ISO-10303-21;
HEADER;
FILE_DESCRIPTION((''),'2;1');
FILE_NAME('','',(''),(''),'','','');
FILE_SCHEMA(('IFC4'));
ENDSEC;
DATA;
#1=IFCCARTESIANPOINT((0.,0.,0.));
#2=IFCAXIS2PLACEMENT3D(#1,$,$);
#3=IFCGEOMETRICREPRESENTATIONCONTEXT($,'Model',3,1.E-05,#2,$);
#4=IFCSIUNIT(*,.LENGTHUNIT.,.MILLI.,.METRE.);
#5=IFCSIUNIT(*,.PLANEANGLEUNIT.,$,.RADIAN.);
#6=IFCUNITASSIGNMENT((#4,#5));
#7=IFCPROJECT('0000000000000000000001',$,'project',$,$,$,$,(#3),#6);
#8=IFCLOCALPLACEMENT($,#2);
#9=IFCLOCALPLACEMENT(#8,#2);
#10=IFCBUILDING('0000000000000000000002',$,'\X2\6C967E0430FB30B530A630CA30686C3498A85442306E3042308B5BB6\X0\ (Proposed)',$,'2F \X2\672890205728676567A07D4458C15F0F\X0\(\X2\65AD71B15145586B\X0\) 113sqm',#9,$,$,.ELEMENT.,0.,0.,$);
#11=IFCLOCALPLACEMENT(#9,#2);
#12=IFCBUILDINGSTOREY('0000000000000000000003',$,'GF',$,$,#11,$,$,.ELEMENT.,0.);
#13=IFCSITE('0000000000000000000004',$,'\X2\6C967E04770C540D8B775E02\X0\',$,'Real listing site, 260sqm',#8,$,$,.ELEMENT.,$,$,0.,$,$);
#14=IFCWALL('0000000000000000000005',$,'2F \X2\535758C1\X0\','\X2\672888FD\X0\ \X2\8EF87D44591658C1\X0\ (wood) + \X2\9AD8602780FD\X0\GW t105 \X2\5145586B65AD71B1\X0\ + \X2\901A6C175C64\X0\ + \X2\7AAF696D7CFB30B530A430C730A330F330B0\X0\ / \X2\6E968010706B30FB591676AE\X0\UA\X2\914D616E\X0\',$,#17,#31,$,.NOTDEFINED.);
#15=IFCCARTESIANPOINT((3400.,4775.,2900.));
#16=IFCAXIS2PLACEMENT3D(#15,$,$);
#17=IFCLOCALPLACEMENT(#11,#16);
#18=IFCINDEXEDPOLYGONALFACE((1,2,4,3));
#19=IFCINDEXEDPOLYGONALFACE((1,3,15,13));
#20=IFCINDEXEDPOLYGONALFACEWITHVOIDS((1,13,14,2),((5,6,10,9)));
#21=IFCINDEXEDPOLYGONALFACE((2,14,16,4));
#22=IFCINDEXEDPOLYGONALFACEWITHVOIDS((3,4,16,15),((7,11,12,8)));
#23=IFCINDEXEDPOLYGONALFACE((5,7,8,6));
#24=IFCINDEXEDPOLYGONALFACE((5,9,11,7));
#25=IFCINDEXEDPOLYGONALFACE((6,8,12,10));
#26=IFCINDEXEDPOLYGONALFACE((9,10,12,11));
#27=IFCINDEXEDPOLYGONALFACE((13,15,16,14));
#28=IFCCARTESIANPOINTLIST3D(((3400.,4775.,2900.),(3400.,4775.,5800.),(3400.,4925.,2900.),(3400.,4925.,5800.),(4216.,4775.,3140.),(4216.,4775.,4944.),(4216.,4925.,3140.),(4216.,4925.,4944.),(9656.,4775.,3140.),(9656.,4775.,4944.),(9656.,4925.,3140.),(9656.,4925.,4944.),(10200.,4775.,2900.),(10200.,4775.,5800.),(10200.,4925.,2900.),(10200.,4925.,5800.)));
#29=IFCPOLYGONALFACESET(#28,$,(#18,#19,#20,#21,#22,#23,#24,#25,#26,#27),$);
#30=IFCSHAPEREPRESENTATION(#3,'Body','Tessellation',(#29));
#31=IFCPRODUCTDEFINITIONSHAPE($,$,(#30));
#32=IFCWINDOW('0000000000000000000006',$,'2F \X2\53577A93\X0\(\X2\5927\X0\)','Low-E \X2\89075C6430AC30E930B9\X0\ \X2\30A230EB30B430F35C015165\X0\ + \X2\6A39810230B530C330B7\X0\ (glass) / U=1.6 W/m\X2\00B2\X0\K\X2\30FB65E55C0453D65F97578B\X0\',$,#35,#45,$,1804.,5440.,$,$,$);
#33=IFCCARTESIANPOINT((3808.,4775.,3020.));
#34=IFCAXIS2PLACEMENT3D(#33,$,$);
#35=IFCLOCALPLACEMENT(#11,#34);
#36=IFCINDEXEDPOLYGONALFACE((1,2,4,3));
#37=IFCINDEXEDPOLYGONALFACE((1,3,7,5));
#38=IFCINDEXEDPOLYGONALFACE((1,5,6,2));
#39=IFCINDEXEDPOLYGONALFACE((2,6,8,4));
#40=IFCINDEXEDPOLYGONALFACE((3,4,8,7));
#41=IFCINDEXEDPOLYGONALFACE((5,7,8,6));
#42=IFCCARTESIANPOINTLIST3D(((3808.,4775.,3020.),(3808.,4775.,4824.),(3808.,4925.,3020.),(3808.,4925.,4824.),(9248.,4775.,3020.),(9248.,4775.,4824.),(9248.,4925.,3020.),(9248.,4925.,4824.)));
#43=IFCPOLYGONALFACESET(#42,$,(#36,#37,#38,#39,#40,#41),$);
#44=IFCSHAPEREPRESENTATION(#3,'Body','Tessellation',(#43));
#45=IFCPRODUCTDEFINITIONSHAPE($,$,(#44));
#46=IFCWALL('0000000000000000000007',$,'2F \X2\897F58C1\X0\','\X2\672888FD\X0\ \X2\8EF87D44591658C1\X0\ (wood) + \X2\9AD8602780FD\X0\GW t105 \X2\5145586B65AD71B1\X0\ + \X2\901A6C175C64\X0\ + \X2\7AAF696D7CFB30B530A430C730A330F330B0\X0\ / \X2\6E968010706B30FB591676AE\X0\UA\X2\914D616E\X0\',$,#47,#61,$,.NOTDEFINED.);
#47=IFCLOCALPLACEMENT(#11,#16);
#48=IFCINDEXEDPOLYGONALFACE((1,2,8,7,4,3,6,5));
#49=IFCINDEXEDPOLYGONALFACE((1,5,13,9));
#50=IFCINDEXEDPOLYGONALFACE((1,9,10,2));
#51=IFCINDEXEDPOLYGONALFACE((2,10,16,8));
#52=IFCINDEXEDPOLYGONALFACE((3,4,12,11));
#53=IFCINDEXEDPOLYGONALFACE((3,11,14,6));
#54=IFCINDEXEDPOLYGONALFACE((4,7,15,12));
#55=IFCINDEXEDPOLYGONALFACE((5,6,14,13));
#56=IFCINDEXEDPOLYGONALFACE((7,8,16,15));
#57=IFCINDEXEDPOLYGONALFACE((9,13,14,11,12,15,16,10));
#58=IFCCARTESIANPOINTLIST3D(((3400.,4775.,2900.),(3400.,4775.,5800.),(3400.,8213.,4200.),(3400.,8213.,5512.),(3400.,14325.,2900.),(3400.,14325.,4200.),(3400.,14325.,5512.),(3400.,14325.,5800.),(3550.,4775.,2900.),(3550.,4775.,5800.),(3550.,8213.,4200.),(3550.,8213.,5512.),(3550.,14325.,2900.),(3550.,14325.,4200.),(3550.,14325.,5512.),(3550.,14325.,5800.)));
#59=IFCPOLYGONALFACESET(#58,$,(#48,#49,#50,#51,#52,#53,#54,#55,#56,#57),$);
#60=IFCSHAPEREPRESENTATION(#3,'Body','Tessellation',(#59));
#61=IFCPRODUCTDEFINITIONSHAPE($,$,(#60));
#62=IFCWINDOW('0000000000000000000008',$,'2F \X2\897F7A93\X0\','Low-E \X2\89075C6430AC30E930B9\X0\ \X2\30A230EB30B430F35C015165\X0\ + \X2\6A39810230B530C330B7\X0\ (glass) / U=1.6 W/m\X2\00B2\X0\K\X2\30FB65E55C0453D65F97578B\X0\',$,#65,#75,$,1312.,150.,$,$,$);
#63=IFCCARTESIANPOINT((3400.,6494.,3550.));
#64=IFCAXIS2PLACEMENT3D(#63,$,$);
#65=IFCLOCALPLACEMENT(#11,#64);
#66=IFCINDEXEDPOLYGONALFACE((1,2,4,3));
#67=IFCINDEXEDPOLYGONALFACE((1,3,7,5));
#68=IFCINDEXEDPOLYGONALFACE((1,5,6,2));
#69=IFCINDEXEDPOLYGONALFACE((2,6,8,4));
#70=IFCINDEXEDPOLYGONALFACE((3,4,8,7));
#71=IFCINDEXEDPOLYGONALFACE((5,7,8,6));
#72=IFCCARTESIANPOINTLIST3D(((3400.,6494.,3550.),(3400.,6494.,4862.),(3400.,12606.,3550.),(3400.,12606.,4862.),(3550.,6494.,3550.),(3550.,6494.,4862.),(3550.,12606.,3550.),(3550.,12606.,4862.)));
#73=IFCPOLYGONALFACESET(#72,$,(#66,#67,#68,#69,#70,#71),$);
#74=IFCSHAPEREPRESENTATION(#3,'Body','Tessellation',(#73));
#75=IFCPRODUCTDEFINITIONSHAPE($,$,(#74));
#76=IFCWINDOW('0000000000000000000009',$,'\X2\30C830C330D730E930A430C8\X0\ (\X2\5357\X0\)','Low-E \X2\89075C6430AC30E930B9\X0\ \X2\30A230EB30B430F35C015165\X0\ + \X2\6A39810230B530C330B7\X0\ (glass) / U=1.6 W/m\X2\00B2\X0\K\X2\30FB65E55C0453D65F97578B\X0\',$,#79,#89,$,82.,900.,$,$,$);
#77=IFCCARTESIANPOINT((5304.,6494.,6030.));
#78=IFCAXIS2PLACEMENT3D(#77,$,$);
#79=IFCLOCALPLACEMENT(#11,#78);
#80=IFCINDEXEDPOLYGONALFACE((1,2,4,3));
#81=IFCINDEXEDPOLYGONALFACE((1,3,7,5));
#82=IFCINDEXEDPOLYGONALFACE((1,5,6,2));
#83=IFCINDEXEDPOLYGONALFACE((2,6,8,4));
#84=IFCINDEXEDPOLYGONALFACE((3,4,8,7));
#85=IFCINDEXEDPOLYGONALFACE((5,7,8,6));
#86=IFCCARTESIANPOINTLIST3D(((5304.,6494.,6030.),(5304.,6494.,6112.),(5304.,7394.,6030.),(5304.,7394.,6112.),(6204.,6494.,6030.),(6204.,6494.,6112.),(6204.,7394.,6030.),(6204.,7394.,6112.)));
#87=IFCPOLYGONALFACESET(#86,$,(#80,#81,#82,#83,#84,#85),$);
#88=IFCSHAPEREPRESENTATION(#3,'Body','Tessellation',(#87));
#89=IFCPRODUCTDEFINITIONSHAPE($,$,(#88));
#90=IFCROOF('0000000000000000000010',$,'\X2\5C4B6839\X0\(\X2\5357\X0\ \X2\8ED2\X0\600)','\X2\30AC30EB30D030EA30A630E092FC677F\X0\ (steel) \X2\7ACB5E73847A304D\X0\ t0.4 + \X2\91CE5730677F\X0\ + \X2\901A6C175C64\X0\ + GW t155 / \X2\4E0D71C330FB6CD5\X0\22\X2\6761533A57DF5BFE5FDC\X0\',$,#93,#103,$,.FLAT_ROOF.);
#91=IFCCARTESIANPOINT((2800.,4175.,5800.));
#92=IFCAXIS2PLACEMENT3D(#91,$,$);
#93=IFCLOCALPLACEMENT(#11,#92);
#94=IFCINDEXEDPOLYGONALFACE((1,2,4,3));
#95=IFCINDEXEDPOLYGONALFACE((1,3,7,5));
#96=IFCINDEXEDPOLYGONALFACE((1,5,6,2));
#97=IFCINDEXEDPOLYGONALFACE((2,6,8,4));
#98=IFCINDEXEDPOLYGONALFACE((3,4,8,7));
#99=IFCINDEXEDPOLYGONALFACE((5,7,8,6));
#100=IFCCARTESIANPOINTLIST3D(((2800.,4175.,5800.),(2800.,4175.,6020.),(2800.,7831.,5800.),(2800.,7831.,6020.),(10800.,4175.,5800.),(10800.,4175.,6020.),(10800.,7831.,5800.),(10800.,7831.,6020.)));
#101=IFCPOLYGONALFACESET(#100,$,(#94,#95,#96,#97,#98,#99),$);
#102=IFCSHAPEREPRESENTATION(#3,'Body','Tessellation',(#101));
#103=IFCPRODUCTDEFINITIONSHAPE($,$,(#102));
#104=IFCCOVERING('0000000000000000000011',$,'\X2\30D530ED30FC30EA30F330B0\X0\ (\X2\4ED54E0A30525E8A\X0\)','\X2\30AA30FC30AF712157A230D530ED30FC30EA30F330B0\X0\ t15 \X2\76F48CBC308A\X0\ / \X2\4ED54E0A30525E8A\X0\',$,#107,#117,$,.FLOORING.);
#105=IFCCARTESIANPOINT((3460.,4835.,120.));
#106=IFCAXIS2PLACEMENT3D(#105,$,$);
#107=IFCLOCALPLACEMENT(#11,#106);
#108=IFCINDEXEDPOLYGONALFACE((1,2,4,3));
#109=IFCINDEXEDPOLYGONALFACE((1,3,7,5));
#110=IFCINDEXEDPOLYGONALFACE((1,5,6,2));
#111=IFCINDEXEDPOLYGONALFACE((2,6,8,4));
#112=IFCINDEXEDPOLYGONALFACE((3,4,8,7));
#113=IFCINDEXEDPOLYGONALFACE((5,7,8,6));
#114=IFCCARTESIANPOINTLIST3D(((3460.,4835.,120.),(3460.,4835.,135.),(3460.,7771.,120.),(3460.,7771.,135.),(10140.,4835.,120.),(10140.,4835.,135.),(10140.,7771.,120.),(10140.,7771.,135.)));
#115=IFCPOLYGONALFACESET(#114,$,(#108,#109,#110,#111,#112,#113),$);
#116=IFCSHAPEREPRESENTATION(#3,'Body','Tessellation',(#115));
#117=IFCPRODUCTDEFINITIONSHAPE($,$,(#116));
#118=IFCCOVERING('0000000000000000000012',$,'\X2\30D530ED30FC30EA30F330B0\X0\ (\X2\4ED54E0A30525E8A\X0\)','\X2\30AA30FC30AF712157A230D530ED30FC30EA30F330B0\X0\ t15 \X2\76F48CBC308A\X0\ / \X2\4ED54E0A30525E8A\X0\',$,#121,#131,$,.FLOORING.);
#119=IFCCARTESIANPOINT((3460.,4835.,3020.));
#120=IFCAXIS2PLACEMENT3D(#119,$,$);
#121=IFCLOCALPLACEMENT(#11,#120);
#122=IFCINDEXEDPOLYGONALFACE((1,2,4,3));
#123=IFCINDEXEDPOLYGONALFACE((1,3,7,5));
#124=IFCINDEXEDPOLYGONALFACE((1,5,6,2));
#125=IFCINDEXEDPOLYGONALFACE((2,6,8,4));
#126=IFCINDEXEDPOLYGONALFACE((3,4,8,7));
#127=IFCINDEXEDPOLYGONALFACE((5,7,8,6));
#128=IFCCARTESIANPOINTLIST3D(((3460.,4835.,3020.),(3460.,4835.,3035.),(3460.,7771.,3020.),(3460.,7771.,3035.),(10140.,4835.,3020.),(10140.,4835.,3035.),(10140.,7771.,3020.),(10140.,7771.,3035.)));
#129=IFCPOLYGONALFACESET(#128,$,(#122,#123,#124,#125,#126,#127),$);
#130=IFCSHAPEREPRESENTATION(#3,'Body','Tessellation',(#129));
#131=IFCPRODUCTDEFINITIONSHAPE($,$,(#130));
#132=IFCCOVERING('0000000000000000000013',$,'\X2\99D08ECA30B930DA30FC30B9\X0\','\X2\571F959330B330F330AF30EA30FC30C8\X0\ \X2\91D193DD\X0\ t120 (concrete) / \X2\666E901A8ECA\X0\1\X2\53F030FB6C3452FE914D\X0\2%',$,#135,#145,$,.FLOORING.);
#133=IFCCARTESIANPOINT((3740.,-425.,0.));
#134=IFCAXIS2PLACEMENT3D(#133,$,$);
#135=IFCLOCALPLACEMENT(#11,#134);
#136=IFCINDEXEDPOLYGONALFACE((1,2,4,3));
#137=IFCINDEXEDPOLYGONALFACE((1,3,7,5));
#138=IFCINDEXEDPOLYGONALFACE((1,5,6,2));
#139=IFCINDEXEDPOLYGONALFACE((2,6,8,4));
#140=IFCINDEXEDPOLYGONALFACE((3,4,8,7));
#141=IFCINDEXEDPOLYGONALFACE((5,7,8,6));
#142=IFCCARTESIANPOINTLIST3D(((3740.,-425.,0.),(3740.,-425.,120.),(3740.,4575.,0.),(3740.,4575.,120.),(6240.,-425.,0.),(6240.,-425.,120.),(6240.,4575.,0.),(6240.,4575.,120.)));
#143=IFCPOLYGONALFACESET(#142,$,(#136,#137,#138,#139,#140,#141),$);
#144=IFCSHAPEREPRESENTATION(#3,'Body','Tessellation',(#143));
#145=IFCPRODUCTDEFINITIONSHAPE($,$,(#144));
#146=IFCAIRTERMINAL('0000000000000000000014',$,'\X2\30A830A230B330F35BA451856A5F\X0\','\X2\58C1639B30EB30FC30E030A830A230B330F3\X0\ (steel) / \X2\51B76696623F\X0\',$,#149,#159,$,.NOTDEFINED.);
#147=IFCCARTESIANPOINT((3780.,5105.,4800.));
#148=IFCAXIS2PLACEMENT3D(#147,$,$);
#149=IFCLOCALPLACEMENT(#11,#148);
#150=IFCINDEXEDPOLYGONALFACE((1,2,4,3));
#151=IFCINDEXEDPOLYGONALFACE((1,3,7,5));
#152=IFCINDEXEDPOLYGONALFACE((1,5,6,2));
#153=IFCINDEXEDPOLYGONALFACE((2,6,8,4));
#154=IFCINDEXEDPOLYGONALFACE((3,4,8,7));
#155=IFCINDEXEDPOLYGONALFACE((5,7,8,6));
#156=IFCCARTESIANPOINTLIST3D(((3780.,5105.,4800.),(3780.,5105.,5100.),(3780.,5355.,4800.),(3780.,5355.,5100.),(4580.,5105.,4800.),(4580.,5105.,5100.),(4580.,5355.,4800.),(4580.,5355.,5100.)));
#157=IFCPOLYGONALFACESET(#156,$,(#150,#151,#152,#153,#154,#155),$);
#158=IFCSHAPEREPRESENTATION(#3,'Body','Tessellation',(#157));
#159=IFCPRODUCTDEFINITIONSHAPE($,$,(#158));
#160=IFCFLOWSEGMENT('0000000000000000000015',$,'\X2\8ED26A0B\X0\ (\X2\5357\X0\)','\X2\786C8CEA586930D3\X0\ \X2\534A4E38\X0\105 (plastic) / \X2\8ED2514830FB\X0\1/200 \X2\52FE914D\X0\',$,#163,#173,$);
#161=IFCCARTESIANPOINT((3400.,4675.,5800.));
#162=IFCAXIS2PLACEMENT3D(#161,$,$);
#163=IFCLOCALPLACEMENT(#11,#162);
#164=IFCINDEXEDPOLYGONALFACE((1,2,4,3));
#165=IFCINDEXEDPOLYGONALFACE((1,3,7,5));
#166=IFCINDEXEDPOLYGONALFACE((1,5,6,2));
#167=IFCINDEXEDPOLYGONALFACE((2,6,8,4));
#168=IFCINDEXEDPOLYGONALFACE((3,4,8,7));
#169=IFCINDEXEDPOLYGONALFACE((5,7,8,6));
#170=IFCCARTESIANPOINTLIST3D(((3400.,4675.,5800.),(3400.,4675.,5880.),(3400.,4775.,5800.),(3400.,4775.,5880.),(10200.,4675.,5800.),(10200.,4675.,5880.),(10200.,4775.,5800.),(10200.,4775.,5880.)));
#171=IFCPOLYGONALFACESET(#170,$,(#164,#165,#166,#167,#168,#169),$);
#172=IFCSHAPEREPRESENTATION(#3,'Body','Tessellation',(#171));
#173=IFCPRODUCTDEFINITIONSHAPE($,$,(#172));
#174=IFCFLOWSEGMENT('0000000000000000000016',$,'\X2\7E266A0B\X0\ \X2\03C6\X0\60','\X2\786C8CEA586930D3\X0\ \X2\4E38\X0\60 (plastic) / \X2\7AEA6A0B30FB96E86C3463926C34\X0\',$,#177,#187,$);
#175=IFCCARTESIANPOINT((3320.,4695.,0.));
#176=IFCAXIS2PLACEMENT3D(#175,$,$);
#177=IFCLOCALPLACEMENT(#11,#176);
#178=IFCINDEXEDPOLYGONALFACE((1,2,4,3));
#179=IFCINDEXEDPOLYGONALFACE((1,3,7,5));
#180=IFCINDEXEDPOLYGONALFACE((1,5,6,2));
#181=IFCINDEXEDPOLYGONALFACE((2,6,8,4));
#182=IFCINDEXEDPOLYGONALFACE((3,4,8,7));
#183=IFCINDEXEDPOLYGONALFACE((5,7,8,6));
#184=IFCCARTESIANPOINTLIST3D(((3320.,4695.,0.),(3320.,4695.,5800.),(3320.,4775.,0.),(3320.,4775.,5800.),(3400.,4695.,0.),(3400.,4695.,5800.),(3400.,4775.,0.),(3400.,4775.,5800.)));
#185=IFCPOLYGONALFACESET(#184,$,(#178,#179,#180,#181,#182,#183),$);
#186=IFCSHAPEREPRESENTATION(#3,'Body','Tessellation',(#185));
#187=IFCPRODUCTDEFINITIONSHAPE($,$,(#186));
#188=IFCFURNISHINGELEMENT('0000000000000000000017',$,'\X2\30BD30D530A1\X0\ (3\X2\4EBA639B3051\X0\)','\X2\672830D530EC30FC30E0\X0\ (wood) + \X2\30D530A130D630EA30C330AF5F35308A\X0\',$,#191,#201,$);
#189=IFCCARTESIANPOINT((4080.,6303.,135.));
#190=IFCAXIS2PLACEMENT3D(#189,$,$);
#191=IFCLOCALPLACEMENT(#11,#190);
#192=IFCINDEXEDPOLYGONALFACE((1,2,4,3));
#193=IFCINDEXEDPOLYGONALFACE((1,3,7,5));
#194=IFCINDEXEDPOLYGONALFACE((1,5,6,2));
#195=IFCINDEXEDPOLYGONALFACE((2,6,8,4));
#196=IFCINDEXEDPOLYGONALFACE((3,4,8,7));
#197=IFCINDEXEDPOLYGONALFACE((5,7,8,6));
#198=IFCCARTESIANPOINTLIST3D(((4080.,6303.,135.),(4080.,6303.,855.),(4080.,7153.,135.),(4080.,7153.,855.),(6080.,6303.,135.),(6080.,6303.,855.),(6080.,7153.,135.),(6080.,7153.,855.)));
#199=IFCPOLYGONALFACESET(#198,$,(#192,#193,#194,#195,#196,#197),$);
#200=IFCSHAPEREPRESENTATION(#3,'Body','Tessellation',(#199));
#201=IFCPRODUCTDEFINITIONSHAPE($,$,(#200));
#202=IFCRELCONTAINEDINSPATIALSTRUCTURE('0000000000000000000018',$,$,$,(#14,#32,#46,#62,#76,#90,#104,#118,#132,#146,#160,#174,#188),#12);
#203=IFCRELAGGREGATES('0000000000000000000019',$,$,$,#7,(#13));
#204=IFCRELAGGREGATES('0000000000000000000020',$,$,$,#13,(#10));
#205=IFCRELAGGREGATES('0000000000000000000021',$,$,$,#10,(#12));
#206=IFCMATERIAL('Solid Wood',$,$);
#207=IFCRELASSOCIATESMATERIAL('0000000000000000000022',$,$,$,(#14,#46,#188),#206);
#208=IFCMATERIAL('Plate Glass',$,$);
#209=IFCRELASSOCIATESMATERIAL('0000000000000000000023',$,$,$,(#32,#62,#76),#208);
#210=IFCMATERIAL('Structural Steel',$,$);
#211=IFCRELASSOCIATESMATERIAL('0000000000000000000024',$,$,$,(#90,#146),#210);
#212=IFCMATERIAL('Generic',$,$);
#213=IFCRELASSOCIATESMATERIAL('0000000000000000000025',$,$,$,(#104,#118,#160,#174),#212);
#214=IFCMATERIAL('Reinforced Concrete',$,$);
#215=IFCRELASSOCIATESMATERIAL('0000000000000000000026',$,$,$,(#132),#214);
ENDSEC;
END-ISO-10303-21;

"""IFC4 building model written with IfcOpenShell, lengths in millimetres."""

from ifc_helpers import new_model, si_unit, frame, frame_2d, origin, place, context, project, spatial, rectangle, extrude, material, element, fill, save


model = new_model("IFC4")

# Units and contexts
model_context = context("Model", 3, precision=1e-05, world=origin())
ifc_project = project(units=[si_unit("LENGTHUNIT", "METRE", prefix="MILLI"), si_unit("PLANEANGLEUNIT", "RADIAN")], contexts=[model_context])

# Site, building, storey
site_placement = place(None, origin())
site = spatial("IfcSite", under=ifc_project, at=site_placement, Name="沖縄県名護市", ObjectType="Real listing site, 260sqm", CompositionType="ELEMENT", RefElevation=0.0)
building_placement = place(site_placement, origin())
building = spatial("IfcBuilding", under=site, at=building_placement, Name="沖縄・サウナと水風呂のある家 (Proposed)", ObjectType="2F 木造在来枠組壁式(断熱充填) 113sqm", CompositionType="ELEMENT", ElevationOfRefHeight=0.0, ElevationOfTerrain=0.0)
storey_placement = place(building_placement, origin())
storey = spatial("IfcBuildingStorey", under=building, at=storey_placement, Name="GF", CompositionType="ELEMENT", Elevation=0.0)

# Shared definitions
ifc_material_1 = material(Name="Solid Wood")

# Shared definitions
ifc_material_2 = material(Name="Reinforced Concrete")

# Shared definitions
ifc_material_3 = material(Name="Plate Glass")

# Walls, openings, windows
wall_1_placement = place(storey_placement, frame((3400.0, 4775.0, 2900.0)))
wall_1 = element("IfcWall", 1, at=wall_1_placement, inside=storey, material=ifc_material_1, Name="2F 南壁", Description="木製 軸組外壁 (wood) + 高性能GW t105 充填断熱 + 通気層 + 窯業系サイディング / 準耐火・外皮UA配慮", PredefinedType="NOTDEFINED", context=model_context, shape_type="SweptSolid", body=[
    extrude(rectangle(XDim=6800.0, YDim=150.0, at=frame_2d((3400.0, 75.0))), frame((3400.0, 4775.0, 2900.0)), (0.0, 0.0, 1.0), 2900.0),
])
opening_1_placement = place(storey_placement, frame((3808.0, 4775.0, 3020.0)))
opening_1 = element("IfcOpeningElement", 2, at=opening_1_placement, cuts=wall_1, PredefinedType="NOTDEFINED", context=model_context, shape_type="SweptSolid", body=[
    extrude(rectangle(XDim=5440.0, YDim=150.0, at=frame_2d((2720.0, 75.0))), frame((3808.0, 4775.0, 3020.0)), (0.0, 0.0, 1.0), 1804.0),
])
window_1_placement = place(storey_placement, frame((3808.0, 4775.0, 3020.0)))
window_1 = element("IfcWindow", 3, at=window_1_placement, inside=storey, material=ifc_material_3, Name="2F 南窓(大)", Description="Low-E 複層ガラス アルゴン封入 + 樹脂サッシ (glass) / U=1.6 W/m²K・日射取得型", OverallHeight=1804.0, OverallWidth=5440.0, context=model_context, shape_type="SweptSolid", body=[
    extrude(rectangle(XDim=5440.0, YDim=150.0, at=frame_2d((2720.0, 75.0))), frame((3808.0, 4775.0, 3020.0)), (0.0, 0.0, 1.0), 1804.0),
])
fill(opening_1, window_1)
wall_2_placement = place(storey_placement, frame((3400.0, 4775.0, 2900.0)))
wall_2 = element("IfcWall", 4, at=wall_2_placement, inside=storey, material=ifc_material_1, Name="2F 西壁", Description="木製 軸組外壁 (wood) + 高性能GW t105 充填断熱 + 通気層 + 窯業系サイディング / 準耐火・外皮UA配慮", PredefinedType="NOTDEFINED", context=model_context, shape_type="SweptSolid", body=[
    extrude(rectangle(XDim=150.0, YDim=9550.0, at=frame_2d((75.0, 4775.0))), frame((3400.0, 4775.0, 2900.0)), (0.0, 0.0, 1.0), 2900.0),
])
opening_2_placement = place(storey_placement, frame((3400.0, 6494.0, 3550.0)))
opening_2 = element("IfcOpeningElement", 5, at=opening_2_placement, cuts=wall_2, PredefinedType="NOTDEFINED", context=model_context, shape_type="SweptSolid", body=[
    extrude(rectangle(XDim=150.0, YDim=6112.0, at=frame_2d((75.0, 3056.0))), frame((3400.0, 6494.0, 3550.0)), (0.0, 0.0, 1.0), 1312.0),
])
window_2_placement = place(storey_placement, frame((3400.0, 6494.0, 3550.0)))
window_2 = element("IfcWindow", 6, at=window_2_placement, inside=storey, material=ifc_material_3, Name="2F 西窓", Description="Low-E 複層ガラス アルゴン封入 + 樹脂サッシ (glass) / U=1.6 W/m²K・日射取得型", OverallHeight=1312.0, OverallWidth=150.0, context=model_context, shape_type="SweptSolid", body=[
    extrude(rectangle(XDim=150.0, YDim=6112.0, at=frame_2d((75.0, 3056.0))), frame((3400.0, 6494.0, 3550.0)), (0.0, 0.0, 1.0), 1312.0),
])
fill(opening_2, window_2)

# Window
window_3_placement = place(storey_placement, frame((5304.0, 6494.0, 6030.0)))
element("IfcWindow", 7, at=window_3_placement, inside=storey, material=ifc_material_3, Name="トップライト (南)", Description="Low-E 複層ガラス アルゴン封入 + 樹脂サッシ (glass) / U=1.6 W/m²K・日射取得型", OverallHeight=82.0, OverallWidth=900.0, context=model_context, shape_type="SweptSolid", body=[
    extrude(rectangle(XDim=900.0, YDim=900.0, at=frame_2d((450.0, 450.0))), frame((5304.0, 6494.0, 6030.0)), (0.0, 0.0, 1.0), 82.0),
])

# Roof
ifc_material_4 = material(Name="Structural Steel")
for number, where, name in (
    (8, (2800.0, 4175.0, 5800.0), "屋根(南 軒600)"),
):
    element("IfcRoof", number, at=place(storey_placement, frame(where)), inside=storey, material=ifc_material_4, Name=name, Description="ガルバリウム鋼板 (steel) 立平葺き t0.4 + 野地板 + 通気層 + GW t155 / 不燃・法22条区域対応", PredefinedType="FLAT_ROOF", context=model_context, shape_type="SweptSolid", body=[
        extrude(rectangle(XDim=8000.0, YDim=3656.0, at=frame_2d((4000.0, 1828.0))), frame((2800.0, 4175.0, 5800.0)), (0.0, 0.0, 1.0), 220.0),
    ])

# Coverings
ifc_material_5 = material(Name="Generic")
covering_1_placement = place(storey_placement, frame((3460.0, 4835.0, 120.0)))
element("IfcCovering", 9, at=covering_1_placement, inside=storey, material=ifc_material_5, Name="フローリング (仕上げ床)", Description="オーク無垢フローリング t15 直貼り / 仕上げ床", PredefinedType="FLOORING", context=model_context, shape_type="SweptSolid", body=[
    extrude(rectangle(XDim=6680.0, YDim=2936.0, at=frame_2d((3340.0, 1468.0))), frame((3460.0, 4835.0, 120.0)), (0.0, 0.0, 1.0), 15.0),
])
covering_2_placement = place(storey_placement, frame((3460.0, 4835.0, 3020.0)))
element("IfcCovering", 10, at=covering_2_placement, inside=storey, material=ifc_material_5, Name="フローリング (仕上げ床)", Description="オーク無垢フローリング t15 直貼り / 仕上げ床", PredefinedType="FLOORING", context=model_context, shape_type="SweptSolid", body=[
    extrude(rectangle(XDim=6680.0, YDim=2936.0, at=frame_2d((3340.0, 1468.0))), frame((3460.0, 4835.0, 3020.0)), (0.0, 0.0, 1.0), 15.0),
])
covering_3_placement = place(storey_placement, frame((3740.0, -425.0, 0.0)))
element("IfcCovering", 11, at=covering_3_placement, inside=storey, material=ifc_material_2, Name="駐車スペース", Description="土間コンクリート 金鏝 t120 (concrete) / 普通車1台・水勾配2%", PredefinedType="FLOORING", context=model_context, shape_type="SweptSolid", body=[
    extrude(rectangle(XDim=2500.0, YDim=5000.0, at=frame_2d((1250.0, 2500.0))), frame((3740.0, -425.0, 0.0)), (0.0, 0.0, 1.0), 120.0),
])

# Air terminal
air_terminal_placement = place(storey_placement, frame((3780.0, 5105.0, 4800.0)))
element("IfcAirTerminal", 12, at=air_terminal_placement, inside=storey, material=ifc_material_4, Name="エアコン室内機", Description="壁掛ルームエアコン (steel) / 冷暖房", PredefinedType="NOTDEFINED", context=model_context, shape_type="SweptSolid", body=[
    extrude(rectangle(XDim=800.0, YDim=250.0, at=frame_2d((400.0, 125.0))), frame((3780.0, 5105.0, 4800.0)), (0.0, 0.0, 1.0), 300.0),
])

# Flow segments
flow_segment_1_placement = place(storey_placement, frame((3400.0, 4675.0, 5800.0)))
element("IfcFlowSegment", 13, at=flow_segment_1_placement, inside=storey, material=ifc_material_5, Name="軒樋 (南)", Description="硬質塩ビ 半丸105 (plastic) / 軒先・1/200 勾配", context=model_context, shape_type="SweptSolid", body=[
    extrude(rectangle(XDim=6800.0, YDim=100.0, at=frame_2d((3400.0, 50.0))), frame((3400.0, 4675.0, 5800.0)), (0.0, 0.0, 1.0), 80.0),
])
flow_segment_2_placement = place(storey_placement, frame((3320.0, 4695.0, 0.0)))
element("IfcFlowSegment", 14, at=flow_segment_2_placement, inside=storey, material=ifc_material_5, Name="縦樋 φ60", Description="硬質塩ビ 丸60 (plastic) / 竪樋・雨水排水", context=model_context, shape_type="SweptSolid", body=[
    extrude(rectangle(XDim=80.0, YDim=80.0, at=frame_2d((40.0, 40.0))), frame((3320.0, 4695.0, 0.0)), (0.0, 0.0, 1.0), 5800.0),
])

# Furnishing element
furnishing_1_placement = place(storey_placement, frame((4080.0, 6303.0, 135.0)))
element("IfcFurnishingElement", 15, at=furnishing_1_placement, inside=storey, material=ifc_material_1, Name="ソファ (3人掛け)", Description="木フレーム (wood) + ファブリック張り", context=model_context, shape_type="SweptSolid", body=[
    extrude(rectangle(XDim=2000.0, YDim=850.0, at=frame_2d((1000.0, 425.0))), frame((4080.0, 6303.0, 135.0)), (0.0, 0.0, 1.0), 720.0),
])

save(model, "model.ifc")
